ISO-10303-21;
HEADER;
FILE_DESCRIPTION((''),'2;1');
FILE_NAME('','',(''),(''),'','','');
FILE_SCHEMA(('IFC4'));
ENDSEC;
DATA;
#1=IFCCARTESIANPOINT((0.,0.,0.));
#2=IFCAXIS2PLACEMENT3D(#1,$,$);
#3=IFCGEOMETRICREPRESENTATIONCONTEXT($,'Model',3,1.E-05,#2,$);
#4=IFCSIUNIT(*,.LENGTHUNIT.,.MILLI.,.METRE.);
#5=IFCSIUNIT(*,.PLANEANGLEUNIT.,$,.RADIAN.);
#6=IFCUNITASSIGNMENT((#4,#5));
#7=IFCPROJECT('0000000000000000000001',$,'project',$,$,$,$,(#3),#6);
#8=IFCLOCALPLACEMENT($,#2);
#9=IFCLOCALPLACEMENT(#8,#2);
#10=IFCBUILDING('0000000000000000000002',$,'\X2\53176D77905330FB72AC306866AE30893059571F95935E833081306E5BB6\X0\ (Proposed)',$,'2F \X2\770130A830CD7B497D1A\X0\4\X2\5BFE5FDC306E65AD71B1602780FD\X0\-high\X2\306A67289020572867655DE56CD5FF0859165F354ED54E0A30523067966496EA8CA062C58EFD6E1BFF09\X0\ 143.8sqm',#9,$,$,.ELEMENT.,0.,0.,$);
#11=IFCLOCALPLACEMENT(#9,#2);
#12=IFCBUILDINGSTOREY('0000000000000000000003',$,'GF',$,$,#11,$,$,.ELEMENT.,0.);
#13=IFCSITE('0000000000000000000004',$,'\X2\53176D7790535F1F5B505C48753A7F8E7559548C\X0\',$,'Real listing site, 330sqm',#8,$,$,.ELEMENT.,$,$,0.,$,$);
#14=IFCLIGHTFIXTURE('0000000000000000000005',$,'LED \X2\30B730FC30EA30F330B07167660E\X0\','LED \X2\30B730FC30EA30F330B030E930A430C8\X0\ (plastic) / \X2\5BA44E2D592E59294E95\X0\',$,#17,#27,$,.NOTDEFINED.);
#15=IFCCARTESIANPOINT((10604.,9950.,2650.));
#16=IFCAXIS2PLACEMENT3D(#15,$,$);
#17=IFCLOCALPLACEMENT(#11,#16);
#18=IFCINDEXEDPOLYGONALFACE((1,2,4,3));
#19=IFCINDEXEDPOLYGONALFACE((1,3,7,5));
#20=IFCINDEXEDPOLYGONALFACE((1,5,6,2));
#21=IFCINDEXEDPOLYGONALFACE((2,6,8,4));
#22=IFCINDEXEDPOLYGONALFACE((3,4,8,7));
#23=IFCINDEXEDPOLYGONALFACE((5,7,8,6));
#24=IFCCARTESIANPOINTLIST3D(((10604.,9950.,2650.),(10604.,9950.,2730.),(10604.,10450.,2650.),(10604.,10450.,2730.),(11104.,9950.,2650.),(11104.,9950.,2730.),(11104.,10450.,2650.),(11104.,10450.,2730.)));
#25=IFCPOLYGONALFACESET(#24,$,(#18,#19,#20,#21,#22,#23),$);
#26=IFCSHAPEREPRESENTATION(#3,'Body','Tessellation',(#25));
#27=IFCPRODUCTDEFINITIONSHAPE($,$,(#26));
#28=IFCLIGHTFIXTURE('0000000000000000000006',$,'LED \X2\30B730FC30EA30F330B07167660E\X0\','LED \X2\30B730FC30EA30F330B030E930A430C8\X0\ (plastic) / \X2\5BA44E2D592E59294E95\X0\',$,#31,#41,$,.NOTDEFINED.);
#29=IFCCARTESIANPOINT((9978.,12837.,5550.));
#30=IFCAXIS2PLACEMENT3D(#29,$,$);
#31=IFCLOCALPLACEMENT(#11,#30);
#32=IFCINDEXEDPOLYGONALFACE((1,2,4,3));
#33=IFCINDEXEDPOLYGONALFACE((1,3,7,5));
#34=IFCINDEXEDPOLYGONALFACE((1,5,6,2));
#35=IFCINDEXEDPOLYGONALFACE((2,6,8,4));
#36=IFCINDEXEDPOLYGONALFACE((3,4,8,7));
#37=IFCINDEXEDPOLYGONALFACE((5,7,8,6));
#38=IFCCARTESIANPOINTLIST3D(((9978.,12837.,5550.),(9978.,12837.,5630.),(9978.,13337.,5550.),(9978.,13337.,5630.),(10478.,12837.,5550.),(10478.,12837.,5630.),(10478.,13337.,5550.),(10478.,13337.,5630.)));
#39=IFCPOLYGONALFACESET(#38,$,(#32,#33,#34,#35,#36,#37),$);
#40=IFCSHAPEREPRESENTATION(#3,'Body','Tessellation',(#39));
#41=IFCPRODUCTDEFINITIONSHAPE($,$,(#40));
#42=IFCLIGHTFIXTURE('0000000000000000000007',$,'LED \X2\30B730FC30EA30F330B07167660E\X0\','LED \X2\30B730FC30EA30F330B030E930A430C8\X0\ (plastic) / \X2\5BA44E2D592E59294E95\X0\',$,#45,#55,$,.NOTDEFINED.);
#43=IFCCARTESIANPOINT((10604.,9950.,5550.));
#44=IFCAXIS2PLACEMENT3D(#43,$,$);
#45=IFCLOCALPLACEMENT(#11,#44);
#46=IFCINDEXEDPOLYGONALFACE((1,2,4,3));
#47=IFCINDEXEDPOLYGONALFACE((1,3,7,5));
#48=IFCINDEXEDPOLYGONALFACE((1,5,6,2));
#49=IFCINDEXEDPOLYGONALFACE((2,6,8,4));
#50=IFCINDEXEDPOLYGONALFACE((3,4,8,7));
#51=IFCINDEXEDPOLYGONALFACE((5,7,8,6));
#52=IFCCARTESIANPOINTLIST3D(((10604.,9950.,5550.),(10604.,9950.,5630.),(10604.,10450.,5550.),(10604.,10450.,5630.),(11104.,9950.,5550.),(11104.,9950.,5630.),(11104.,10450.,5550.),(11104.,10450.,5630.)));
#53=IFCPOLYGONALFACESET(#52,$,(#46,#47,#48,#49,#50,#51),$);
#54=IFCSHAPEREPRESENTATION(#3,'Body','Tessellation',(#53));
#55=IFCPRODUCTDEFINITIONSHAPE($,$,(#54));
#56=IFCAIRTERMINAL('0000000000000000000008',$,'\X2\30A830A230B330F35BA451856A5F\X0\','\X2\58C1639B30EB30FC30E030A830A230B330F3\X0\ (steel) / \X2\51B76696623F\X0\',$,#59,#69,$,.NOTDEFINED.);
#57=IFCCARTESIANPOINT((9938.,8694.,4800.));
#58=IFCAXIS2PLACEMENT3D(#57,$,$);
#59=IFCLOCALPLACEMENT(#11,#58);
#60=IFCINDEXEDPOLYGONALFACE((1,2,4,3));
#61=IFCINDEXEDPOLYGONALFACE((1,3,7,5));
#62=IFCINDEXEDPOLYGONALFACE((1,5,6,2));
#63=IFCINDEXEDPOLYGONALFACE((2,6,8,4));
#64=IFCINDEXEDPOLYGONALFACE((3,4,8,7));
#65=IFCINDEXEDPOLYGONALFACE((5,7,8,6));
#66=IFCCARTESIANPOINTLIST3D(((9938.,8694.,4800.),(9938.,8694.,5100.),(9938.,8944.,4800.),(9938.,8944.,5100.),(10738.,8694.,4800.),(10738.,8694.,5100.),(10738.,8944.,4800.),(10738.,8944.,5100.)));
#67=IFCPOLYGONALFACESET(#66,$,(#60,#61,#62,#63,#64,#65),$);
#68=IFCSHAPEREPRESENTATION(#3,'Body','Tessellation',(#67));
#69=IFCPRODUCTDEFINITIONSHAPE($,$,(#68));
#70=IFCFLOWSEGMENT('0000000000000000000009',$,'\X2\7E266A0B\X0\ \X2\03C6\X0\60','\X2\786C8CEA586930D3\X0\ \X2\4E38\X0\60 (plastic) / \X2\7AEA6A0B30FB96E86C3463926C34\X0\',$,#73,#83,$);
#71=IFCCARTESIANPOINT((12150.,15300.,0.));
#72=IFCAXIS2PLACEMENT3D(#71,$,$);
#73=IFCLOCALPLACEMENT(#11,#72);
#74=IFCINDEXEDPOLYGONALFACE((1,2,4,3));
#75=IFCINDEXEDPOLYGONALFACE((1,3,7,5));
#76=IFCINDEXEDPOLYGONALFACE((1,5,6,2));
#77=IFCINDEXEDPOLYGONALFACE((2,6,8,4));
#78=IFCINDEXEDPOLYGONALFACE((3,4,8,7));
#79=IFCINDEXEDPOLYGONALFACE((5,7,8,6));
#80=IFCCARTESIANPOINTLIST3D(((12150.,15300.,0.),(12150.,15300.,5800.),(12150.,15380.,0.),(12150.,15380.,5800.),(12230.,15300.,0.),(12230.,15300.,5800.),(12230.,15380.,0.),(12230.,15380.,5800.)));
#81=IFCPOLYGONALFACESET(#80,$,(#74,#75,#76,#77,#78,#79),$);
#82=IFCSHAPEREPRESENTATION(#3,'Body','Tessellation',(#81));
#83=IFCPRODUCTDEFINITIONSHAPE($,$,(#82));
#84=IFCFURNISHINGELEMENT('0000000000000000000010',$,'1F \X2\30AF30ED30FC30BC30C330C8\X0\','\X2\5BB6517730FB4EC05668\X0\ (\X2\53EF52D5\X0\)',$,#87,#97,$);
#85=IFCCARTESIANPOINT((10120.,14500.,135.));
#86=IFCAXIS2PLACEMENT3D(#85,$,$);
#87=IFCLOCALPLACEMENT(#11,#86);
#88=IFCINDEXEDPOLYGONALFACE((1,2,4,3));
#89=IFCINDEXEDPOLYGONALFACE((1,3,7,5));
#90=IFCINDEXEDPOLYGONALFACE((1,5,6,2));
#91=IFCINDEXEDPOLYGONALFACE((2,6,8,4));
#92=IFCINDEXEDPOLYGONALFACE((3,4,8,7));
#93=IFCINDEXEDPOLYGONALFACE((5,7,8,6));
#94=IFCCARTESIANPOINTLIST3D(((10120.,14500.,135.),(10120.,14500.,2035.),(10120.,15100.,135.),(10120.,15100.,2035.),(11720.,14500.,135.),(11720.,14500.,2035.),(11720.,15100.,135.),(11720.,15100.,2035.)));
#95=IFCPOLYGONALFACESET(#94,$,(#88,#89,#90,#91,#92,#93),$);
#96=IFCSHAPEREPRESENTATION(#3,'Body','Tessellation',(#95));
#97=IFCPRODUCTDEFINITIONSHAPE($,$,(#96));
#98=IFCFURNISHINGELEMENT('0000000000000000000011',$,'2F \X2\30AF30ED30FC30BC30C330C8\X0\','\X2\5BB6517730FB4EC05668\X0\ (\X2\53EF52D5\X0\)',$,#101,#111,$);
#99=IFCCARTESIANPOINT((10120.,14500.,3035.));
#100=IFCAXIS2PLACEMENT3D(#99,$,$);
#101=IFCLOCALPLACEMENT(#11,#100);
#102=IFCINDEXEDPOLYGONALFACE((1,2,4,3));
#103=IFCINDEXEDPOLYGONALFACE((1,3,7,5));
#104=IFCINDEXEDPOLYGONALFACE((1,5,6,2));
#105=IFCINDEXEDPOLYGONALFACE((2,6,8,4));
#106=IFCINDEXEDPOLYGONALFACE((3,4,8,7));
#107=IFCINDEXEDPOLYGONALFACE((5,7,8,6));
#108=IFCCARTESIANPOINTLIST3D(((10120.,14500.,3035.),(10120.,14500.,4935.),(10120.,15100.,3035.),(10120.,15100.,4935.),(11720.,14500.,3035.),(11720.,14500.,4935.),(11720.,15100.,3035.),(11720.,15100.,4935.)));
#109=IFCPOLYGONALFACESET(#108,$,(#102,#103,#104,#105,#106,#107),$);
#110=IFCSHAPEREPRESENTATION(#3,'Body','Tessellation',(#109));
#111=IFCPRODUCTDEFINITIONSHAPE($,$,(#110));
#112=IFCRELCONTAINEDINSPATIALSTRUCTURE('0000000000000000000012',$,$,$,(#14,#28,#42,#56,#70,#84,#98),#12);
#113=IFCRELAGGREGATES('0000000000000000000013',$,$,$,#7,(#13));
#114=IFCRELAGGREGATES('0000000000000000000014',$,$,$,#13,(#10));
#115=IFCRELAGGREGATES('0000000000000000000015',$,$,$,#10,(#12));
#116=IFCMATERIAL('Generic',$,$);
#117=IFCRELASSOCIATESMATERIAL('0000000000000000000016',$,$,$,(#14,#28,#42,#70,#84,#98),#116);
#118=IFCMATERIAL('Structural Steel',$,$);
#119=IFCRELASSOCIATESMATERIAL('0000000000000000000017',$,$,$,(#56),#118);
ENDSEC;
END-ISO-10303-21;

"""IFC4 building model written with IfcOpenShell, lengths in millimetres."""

from ifc_helpers import new_model, si_unit, frame, frame_2d, origin, place, context, project, spatial, rectangle, extrude, material, element, save


model = new_model("IFC4")

# Units and contexts
model_context = context("Model", 3, precision=1e-05, world=origin())
ifc_project = project(units=[si_unit("LENGTHUNIT", "METRE", prefix="MILLI"), si_unit("PLANEANGLEUNIT", "RADIAN")], contexts=[model_context])

# Site, building, storey
site_placement = place(None, origin())
site = spatial("IfcSite", under=ifc_project, at=site_placement, Name="北海道弟子屈町美留和", ObjectType="Real listing site, 330sqm", CompositionType="ELEMENT", RefElevation=0.0)
building_placement = place(site_placement, origin())
building = spatial("IfcBuilding", under=site, at=building_placement, Name="北海道・犬と暮らす土間広めの家 (Proposed)", ObjectType="2F 省エネ等級4対応の断熱性能-highな木造在来工法（外張仕上げで除雪負担軽減） 143.8sqm", CompositionType="ELEMENT", ElevationOfRefHeight=0.0, ElevationOfTerrain=0.0)
storey_placement = place(building_placement, origin())
storey = spatial("IfcBuildingStorey", under=building, at=storey_placement, Name="GF", CompositionType="ELEMENT", Elevation=0.0)

# Shared definitions
ifc_material_1 = material(Name="Structural Steel")

# Shared definitions
ifc_material_2 = material(Name="Generic")

# Light fixtures
light_fixture_1_placement = place(storey_placement, frame((10604.0, 9950.0, 2650.0)))
element("IfcLightFixture", 1, at=light_fixture_1_placement, inside=storey, material=ifc_material_2, Name="LED シーリング照明", Description="LED シーリングライト (plastic) / 室中央天井", PredefinedType="NOTDEFINED", context=model_context, shape_type="SweptSolid", body=[
    extrude(rectangle(XDim=500.0, YDim=500.0, at=frame_2d((250.0, 250.0))), frame((10604.0, 9950.0, 2650.0)), (0.0, 0.0, 1.0), 80.0),
])
light_fixture_2_placement = place(storey_placement, frame((9978.0, 12837.0, 5550.0)))
element("IfcLightFixture", 2, at=light_fixture_2_placement, inside=storey, material=ifc_material_2, Name="LED シーリング照明", Description="LED シーリングライト (plastic) / 室中央天井", PredefinedType="NOTDEFINED", context=model_context, shape_type="SweptSolid", body=[
    extrude(rectangle(XDim=500.0, YDim=500.0, at=frame_2d((250.0, 250.0))), frame((9978.0, 12837.0, 5550.0)), (0.0, 0.0, 1.0), 80.0),
])
light_fixture_3_placement = place(storey_placement, frame((10604.0, 9950.0, 5550.0)))
element("IfcLightFixture", 3, at=light_fixture_3_placement, inside=storey, material=ifc_material_2, Name="LED シーリング照明", Description="LED シーリングライト (plastic) / 室中央天井", PredefinedType="NOTDEFINED", context=model_context, shape_type="SweptSolid", body=[
    extrude(rectangle(XDim=500.0, YDim=500.0, at=frame_2d((250.0, 250.0))), frame((10604.0, 9950.0, 5550.0)), (0.0, 0.0, 1.0), 80.0),
])

# Air terminal
air_terminal_placement = place(storey_placement, frame((9938.0, 8694.0, 4800.0)))
element("IfcAirTerminal", 4, at=air_terminal_placement, inside=storey, material=ifc_material_1, Name="エアコン室内機", Description="壁掛ルームエアコン (steel) / 冷暖房", PredefinedType="NOTDEFINED", context=model_context, shape_type="SweptSolid", body=[
    extrude(rectangle(XDim=800.0, YDim=250.0, at=frame_2d((400.0, 125.0))), frame((9938.0, 8694.0, 4800.0)), (0.0, 0.0, 1.0), 300.0),
])

# Flow segment
flow_segment_placement = place(storey_placement, frame((12150.0, 15300.0, 0.0)))
element("IfcFlowSegment", 5, at=flow_segment_placement, inside=storey, material=ifc_material_2, Name="縦樋 φ60", Description="硬質塩ビ 丸60 (plastic) / 竪樋・雨水排水", context=model_context, shape_type="SweptSolid", body=[
    extrude(rectangle(XDim=80.0, YDim=80.0, at=frame_2d((40.0, 40.0))), frame((12150.0, 15300.0, 0.0)), (0.0, 0.0, 1.0), 5800.0),
])

# Furnishing elements
furnishing_1_placement = place(storey_placement, frame((10120.0, 14500.0, 135.0)))
element("IfcFurnishingElement", 6, at=furnishing_1_placement, inside=storey, material=ifc_material_2, Name="1F クローゼット", Description="家具・什器 (可動)", context=model_context, shape_type="SweptSolid", body=[
    extrude(rectangle(XDim=1600.0, YDim=600.0, at=frame_2d((800.0, 300.0))), frame((10120.0, 14500.0, 135.0)), (0.0, 0.0, 1.0), 1900.0),
])
furnishing_2_placement = place(storey_placement, frame((10120.0, 14500.0, 3035.0)))
element("IfcFurnishingElement", 7, at=furnishing_2_placement, inside=storey, material=ifc_material_2, Name="2F クローゼット", Description="家具・什器 (可動)", context=model_context, shape_type="SweptSolid", body=[
    extrude(rectangle(XDim=1600.0, YDim=600.0, at=frame_2d((800.0, 300.0))), frame((10120.0, 14500.0, 3035.0)), (0.0, 0.0, 1.0), 1900.0),
])

save(model, "model.ifc")
